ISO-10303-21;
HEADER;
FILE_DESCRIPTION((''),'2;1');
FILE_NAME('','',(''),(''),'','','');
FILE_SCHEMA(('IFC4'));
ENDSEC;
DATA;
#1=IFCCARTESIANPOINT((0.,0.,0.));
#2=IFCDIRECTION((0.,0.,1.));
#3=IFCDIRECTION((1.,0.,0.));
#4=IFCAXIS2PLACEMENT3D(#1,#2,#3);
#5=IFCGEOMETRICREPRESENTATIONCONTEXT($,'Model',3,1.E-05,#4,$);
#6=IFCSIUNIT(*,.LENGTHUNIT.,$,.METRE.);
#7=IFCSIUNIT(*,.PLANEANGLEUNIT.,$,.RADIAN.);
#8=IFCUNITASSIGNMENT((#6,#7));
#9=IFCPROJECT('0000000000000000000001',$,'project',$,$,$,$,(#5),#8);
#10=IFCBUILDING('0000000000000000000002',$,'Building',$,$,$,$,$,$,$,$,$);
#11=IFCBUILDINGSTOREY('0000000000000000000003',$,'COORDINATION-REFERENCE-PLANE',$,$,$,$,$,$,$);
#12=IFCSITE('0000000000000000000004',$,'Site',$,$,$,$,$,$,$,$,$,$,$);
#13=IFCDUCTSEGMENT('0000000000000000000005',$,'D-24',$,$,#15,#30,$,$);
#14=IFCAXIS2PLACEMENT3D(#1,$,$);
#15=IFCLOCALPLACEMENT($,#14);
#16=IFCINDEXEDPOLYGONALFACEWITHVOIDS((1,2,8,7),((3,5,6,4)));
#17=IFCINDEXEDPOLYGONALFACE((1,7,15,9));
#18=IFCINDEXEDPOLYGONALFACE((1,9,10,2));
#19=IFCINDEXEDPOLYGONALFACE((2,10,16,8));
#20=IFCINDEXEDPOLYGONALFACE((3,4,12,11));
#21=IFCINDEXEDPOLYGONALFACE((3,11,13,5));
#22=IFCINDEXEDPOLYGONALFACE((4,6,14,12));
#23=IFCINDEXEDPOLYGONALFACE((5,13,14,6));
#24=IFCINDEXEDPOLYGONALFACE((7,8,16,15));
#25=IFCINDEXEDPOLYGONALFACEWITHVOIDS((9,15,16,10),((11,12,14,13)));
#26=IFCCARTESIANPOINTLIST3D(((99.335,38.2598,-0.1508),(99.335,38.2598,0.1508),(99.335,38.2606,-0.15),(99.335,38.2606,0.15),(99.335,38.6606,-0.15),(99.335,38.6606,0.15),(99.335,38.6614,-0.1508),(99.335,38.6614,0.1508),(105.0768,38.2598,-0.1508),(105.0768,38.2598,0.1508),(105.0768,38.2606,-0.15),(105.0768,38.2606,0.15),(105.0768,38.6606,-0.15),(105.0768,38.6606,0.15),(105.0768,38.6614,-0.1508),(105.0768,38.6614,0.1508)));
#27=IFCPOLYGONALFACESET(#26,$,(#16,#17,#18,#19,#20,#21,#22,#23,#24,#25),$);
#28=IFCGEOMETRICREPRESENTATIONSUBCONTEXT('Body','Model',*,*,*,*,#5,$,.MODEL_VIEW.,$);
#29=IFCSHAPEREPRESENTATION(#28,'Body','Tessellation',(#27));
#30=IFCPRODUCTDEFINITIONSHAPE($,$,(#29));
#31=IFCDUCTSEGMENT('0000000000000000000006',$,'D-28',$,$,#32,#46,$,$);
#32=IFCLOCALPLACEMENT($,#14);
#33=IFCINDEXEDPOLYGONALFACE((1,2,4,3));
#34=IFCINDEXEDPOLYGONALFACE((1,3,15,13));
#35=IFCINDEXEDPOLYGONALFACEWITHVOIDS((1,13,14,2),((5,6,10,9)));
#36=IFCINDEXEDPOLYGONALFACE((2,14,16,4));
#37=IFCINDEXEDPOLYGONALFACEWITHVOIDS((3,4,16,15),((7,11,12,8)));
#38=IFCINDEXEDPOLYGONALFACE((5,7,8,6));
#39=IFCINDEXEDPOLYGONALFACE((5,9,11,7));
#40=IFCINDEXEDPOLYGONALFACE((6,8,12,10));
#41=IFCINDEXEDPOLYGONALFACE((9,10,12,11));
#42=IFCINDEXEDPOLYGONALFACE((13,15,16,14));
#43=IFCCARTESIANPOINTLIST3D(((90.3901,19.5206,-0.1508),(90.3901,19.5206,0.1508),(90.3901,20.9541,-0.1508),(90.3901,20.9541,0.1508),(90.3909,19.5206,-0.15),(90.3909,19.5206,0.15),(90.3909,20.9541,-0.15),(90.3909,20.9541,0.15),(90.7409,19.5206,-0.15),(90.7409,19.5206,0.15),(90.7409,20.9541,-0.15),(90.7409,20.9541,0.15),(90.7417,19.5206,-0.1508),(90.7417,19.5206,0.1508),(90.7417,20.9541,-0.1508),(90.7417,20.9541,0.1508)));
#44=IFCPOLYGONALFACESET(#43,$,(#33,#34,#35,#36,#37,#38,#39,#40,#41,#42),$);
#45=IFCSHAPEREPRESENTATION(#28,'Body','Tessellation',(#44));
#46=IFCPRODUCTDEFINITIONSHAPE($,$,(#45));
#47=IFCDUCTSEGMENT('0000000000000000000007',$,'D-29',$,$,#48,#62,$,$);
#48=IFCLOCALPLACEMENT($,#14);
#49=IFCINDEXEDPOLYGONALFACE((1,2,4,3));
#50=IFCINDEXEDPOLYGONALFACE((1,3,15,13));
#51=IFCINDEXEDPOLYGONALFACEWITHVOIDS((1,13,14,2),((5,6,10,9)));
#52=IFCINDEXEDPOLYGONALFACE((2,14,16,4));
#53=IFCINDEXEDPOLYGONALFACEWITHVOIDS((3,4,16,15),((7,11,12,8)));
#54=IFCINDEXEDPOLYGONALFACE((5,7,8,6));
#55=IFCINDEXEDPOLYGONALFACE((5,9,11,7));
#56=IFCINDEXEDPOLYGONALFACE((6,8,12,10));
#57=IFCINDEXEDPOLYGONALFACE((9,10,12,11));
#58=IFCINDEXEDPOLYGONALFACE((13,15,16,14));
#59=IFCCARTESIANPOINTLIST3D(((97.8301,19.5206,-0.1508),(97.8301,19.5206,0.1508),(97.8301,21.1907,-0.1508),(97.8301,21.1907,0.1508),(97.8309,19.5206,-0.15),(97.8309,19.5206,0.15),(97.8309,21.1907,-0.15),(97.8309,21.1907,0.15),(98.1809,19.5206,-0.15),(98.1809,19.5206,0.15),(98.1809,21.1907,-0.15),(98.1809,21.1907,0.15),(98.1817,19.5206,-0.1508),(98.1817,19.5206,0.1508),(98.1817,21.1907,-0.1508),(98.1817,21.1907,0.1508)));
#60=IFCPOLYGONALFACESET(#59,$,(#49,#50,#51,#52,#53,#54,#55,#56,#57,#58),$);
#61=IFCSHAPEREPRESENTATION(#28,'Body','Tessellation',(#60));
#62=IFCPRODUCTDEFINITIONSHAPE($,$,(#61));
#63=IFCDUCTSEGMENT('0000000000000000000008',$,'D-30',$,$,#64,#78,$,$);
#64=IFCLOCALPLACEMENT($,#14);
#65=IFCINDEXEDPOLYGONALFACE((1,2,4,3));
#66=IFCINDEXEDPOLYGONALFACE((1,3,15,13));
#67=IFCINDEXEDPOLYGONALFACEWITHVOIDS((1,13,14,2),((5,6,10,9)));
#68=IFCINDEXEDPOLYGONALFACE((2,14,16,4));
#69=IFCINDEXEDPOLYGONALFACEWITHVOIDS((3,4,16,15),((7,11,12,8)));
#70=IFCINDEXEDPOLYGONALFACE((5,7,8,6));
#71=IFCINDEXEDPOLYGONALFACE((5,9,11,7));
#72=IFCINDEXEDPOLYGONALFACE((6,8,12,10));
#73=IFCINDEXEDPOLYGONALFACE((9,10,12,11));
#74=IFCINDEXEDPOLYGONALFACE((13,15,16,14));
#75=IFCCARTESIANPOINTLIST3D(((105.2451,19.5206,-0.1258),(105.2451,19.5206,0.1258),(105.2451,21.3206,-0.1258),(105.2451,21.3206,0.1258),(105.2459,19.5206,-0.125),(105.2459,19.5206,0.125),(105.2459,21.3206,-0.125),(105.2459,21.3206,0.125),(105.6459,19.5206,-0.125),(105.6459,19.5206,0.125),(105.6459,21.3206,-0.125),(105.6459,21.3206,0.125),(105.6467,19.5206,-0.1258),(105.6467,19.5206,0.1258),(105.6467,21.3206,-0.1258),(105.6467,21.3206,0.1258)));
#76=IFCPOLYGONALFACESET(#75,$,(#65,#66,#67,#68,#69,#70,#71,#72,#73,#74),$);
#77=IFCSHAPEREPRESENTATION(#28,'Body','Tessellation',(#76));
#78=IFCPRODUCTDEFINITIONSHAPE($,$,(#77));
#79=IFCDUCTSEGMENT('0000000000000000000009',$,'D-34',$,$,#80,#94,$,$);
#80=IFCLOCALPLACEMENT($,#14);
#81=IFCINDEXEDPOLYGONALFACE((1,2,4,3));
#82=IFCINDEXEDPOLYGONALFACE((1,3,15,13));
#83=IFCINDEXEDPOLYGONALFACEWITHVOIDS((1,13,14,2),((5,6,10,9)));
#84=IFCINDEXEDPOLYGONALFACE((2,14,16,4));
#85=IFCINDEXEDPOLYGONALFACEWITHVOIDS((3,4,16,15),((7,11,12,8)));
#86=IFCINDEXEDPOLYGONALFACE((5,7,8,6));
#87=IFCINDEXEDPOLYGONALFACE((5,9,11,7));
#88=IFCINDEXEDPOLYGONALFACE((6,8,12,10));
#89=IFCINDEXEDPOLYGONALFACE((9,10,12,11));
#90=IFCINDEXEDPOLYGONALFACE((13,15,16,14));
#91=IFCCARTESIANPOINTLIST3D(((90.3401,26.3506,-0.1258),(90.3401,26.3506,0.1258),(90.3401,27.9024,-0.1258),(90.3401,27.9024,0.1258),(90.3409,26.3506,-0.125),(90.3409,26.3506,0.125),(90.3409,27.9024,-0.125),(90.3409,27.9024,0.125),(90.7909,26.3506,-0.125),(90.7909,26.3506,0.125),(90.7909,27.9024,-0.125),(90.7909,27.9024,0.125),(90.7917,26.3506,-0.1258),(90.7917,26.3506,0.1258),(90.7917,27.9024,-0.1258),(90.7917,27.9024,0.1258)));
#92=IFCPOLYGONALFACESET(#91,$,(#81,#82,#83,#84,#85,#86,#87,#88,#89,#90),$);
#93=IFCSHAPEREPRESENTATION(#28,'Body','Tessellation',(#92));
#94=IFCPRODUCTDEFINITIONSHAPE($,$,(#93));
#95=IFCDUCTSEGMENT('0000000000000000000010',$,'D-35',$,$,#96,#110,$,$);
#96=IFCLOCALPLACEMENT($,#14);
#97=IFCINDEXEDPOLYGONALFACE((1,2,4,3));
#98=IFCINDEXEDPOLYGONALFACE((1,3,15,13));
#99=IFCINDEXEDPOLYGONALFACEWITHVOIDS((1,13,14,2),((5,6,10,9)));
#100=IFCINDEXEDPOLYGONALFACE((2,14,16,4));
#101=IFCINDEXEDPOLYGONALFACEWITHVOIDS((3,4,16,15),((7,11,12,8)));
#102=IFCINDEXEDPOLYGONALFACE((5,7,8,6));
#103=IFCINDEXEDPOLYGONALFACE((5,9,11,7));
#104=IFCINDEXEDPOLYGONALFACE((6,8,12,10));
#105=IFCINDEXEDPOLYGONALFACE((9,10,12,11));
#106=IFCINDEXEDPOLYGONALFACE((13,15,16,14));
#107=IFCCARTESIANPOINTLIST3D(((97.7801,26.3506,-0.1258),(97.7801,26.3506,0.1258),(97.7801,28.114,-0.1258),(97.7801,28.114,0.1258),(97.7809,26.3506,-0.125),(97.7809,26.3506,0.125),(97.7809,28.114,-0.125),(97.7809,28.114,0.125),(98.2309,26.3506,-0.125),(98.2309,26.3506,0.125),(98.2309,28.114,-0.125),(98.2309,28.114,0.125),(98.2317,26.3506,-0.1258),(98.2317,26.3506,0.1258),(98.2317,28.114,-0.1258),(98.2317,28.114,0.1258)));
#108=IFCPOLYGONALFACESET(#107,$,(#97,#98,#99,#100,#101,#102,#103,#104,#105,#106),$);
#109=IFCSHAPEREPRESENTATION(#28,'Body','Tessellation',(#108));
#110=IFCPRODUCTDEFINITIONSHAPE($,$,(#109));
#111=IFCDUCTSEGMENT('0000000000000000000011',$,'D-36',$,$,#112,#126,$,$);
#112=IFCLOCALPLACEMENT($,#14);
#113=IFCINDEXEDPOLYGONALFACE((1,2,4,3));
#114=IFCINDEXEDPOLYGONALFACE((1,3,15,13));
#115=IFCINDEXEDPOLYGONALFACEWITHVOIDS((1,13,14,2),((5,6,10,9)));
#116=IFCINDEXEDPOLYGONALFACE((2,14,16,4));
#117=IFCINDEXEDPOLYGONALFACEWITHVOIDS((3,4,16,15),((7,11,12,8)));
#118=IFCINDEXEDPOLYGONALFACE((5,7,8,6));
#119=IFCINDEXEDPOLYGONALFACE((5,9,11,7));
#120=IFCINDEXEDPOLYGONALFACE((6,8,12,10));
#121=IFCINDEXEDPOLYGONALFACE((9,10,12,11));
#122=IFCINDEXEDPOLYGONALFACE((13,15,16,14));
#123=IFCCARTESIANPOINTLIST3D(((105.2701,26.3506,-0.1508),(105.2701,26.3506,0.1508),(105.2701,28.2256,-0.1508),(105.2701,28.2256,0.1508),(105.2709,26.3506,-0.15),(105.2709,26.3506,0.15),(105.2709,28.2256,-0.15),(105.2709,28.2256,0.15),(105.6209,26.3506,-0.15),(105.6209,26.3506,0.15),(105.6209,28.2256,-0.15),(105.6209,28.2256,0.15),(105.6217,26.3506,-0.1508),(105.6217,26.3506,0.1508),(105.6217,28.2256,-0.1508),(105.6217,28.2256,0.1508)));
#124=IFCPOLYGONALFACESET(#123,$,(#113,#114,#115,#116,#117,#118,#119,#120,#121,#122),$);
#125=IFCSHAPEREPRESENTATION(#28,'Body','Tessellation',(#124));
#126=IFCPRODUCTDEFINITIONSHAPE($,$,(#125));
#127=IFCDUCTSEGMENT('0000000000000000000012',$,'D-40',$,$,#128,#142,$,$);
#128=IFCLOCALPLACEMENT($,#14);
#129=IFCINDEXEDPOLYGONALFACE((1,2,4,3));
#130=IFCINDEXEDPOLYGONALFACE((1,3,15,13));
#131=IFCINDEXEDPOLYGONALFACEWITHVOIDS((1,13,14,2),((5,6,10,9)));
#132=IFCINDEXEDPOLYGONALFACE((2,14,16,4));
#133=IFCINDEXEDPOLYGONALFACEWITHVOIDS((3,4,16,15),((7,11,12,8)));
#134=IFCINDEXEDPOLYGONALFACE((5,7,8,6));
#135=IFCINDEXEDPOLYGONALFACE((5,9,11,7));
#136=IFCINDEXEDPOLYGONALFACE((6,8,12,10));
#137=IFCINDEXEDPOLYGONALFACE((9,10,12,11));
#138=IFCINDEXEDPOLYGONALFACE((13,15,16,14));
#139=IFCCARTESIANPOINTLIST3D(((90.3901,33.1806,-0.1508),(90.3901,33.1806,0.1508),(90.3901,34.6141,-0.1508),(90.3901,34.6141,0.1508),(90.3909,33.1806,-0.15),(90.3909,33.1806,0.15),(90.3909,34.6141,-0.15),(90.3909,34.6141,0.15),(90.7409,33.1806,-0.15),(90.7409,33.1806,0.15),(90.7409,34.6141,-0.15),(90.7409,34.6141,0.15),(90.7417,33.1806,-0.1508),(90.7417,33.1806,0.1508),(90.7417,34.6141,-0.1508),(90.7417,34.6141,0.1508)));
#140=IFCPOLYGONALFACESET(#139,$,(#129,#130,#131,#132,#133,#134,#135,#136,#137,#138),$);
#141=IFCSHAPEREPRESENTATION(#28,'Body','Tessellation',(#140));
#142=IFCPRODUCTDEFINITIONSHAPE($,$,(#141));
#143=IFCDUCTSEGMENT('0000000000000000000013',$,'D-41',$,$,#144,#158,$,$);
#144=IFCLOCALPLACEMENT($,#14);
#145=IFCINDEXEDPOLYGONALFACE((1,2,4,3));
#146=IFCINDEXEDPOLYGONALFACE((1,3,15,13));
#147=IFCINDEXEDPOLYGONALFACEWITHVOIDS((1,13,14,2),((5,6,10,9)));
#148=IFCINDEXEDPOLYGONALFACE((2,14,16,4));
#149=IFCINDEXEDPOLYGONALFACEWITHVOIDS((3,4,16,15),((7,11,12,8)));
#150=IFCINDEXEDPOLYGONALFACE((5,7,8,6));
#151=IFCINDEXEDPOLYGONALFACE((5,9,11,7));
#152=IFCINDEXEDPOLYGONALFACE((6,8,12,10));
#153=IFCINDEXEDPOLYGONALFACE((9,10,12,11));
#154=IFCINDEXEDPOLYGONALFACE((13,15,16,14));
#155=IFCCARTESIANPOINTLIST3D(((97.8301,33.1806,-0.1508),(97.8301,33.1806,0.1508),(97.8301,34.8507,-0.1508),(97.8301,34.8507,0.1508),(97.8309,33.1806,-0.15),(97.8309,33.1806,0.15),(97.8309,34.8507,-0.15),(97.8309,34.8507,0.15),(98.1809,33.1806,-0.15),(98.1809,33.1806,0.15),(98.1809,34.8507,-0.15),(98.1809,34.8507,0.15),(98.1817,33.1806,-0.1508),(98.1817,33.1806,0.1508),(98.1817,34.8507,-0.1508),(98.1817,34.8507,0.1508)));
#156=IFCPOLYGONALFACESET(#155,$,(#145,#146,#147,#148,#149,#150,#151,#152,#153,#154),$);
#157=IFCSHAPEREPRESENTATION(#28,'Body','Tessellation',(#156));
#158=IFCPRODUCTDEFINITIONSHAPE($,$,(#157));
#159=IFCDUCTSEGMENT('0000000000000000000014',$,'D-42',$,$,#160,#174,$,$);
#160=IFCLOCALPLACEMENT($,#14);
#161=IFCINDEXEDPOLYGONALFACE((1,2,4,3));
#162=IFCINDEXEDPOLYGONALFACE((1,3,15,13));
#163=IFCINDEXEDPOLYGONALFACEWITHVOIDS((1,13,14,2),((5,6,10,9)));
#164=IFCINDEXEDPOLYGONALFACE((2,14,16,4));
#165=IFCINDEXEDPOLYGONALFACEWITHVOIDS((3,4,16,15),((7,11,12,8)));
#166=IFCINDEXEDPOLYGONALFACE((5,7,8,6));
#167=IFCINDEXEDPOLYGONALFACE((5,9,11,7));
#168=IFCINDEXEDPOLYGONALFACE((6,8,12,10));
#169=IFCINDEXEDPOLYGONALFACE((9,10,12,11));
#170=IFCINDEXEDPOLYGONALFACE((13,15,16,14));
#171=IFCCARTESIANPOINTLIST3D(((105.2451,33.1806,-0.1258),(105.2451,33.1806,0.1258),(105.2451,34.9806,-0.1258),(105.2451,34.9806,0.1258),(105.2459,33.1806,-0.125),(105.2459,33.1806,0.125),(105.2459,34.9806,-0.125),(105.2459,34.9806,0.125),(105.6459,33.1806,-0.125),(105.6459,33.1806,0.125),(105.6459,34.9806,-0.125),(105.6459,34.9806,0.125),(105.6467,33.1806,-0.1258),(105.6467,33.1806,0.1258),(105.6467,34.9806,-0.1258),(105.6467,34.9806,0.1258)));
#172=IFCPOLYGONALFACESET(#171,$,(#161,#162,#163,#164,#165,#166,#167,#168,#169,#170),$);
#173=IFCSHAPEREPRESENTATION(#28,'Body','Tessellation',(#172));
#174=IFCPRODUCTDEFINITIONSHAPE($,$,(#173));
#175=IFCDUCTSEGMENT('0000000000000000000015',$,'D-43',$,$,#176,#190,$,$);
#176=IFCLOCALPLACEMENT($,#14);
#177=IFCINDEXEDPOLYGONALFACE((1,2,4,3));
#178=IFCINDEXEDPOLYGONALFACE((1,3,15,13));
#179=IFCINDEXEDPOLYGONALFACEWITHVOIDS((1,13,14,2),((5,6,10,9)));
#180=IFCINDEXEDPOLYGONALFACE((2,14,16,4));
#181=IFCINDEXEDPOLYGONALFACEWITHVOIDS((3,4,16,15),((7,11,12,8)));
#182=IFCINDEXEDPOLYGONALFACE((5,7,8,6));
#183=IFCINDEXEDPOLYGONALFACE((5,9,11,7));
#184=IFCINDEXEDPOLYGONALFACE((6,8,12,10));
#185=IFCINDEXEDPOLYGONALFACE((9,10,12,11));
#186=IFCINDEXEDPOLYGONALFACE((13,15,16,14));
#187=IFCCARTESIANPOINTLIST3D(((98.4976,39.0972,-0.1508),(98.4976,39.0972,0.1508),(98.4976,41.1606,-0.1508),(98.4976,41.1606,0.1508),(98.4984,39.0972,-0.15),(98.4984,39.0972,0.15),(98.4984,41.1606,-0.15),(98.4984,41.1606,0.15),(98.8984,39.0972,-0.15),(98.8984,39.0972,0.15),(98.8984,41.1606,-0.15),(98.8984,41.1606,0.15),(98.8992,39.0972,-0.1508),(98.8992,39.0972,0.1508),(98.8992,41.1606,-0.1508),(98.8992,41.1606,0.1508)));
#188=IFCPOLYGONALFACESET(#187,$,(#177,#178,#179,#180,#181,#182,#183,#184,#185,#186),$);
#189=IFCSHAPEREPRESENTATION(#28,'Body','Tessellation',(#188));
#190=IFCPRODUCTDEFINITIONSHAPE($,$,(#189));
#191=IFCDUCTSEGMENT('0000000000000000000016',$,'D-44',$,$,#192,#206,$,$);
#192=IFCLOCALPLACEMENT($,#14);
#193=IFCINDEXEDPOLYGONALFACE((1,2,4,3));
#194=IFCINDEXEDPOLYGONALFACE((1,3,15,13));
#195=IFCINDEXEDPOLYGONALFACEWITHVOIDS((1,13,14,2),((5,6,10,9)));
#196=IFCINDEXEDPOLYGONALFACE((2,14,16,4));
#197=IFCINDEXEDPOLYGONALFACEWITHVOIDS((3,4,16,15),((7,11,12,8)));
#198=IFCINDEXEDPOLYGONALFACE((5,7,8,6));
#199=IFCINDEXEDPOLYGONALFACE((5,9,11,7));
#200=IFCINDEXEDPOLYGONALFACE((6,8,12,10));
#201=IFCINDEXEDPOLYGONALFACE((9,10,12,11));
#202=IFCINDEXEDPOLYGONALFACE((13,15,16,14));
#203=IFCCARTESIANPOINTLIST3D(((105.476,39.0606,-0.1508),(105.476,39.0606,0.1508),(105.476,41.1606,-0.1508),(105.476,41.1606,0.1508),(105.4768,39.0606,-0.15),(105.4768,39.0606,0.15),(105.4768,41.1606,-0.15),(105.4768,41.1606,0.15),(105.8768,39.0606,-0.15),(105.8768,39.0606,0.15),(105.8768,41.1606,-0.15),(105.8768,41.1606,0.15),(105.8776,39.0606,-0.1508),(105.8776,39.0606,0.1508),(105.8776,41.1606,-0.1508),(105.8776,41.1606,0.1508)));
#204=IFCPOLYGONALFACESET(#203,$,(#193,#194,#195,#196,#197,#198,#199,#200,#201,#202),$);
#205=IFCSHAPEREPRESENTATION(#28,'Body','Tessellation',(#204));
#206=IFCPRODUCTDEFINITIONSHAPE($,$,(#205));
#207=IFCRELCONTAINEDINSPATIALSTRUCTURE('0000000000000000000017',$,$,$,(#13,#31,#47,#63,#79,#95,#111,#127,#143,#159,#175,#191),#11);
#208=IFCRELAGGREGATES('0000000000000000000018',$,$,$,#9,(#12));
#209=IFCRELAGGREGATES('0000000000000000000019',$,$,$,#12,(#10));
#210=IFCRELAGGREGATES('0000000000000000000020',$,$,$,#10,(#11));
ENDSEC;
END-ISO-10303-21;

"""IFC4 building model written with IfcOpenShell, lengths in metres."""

from ifc_helpers import new_model, si_unit, frame, origin, origin_with_axes, place, context, subcontext, project, spatial, hollow_rectangle, extrude, element, save


model = new_model("IFC4")

# Units and contexts
model_context = context("Model", 3, precision=1e-05, world=origin_with_axes())
body_context = subcontext(model_context, "Body", "Model", "MODEL_VIEW")
ifc_project = project(units=[si_unit("LENGTHUNIT", "METRE"), si_unit("PLANEANGLEUNIT", "RADIAN")], contexts=[model_context])

# Site, building, storey
site = spatial("IfcSite", under=ifc_project, Name="Site")
building = spatial("IfcBuilding", under=site, Name="Building")
storey = spatial("IfcBuildingStorey", under=building, Name="COORDINATION-REFERENCE-PLANE")

# Duct segments
duct_segment_1_placement = place(None, frame((99.335, 38.4606, 0.0), z_axis=(1.0, 0.0, 0.0), x_axis=(0.0, 1.0, 0.0)))
element("IfcDuctSegment", 1, at=duct_segment_1_placement, inside=storey, Name="D-24", context=body_context, shape_type="SweptSolid", body=[
    extrude(hollow_rectangle(XDim=0.4016, YDim=0.3016, WallThickness=0.0008), origin(), (0.0, 0.0, 1.0), 5.7417),
])
duct_segment_2_placement = place(None, frame((90.5659, 19.5206, 0.0), z_axis=(0.0, 1.0, 0.0), x_axis=(1.0, 0.0, 0.0)))
element("IfcDuctSegment", 2, at=duct_segment_2_placement, inside=storey, Name="D-28", context=body_context, shape_type="SweptSolid", body=[
    extrude(hollow_rectangle(XDim=0.3516, YDim=0.3016, WallThickness=0.0008), origin(), (0.0, 0.0, 1.0), 1.4335),
])
duct_segment_3_placement = place(None, frame((98.0059, 19.5206, 0.0), z_axis=(0.0, 1.0, 0.0), x_axis=(1.0, 0.0, 0.0)))
element("IfcDuctSegment", 3, at=duct_segment_3_placement, inside=storey, Name="D-29", context=body_context, shape_type="SweptSolid", body=[
    extrude(hollow_rectangle(XDim=0.3516, YDim=0.3016, WallThickness=0.0008), origin(), (0.0, 0.0, 1.0), 1.6701),
])
duct_segment_4_placement = place(None, frame((105.4459, 19.5206, 0.0), z_axis=(0.0, 1.0, 0.0), x_axis=(1.0, 0.0, 0.0)))
element("IfcDuctSegment", 4, at=duct_segment_4_placement, inside=storey, Name="D-30", context=body_context, shape_type="SweptSolid", body=[
    extrude(hollow_rectangle(XDim=0.4016, YDim=0.2516, WallThickness=0.0008), origin(), (0.0, 0.0, 1.0), 1.8),
])
duct_segment_5_placement = place(None, frame((90.5659, 26.3506, 0.0), z_axis=(0.0, 1.0, 0.0), x_axis=(1.0, 0.0, 0.0)))
element("IfcDuctSegment", 5, at=duct_segment_5_placement, inside=storey, Name="D-34", context=body_context, shape_type="SweptSolid", body=[
    extrude(hollow_rectangle(XDim=0.4516, YDim=0.2516, WallThickness=0.0008), origin(), (0.0, 0.0, 1.0), 1.5518),
])
duct_segment_6_placement = place(None, frame((98.0059, 26.3506, 0.0), z_axis=(0.0, 1.0, 0.0), x_axis=(1.0, 0.0, 0.0)))
element("IfcDuctSegment", 6, at=duct_segment_6_placement, inside=storey, Name="D-35", context=body_context, shape_type="SweptSolid", body=[
    extrude(hollow_rectangle(XDim=0.4516, YDim=0.2516, WallThickness=0.0008), origin(), (0.0, 0.0, 1.0), 1.7634),
])
duct_segment_7_placement = place(None, frame((105.4459, 26.3506, 0.0), z_axis=(0.0, 1.0, 0.0), x_axis=(1.0, 0.0, 0.0)))
element("IfcDuctSegment", 7, at=duct_segment_7_placement, inside=storey, Name="D-36", context=body_context, shape_type="SweptSolid", body=[
    extrude(hollow_rectangle(XDim=0.3516, YDim=0.3016, WallThickness=0.0008), origin(), (0.0, 0.0, 1.0), 1.875),
])
duct_segment_8_placement = place(None, frame((90.5659, 33.1806, 0.0), z_axis=(0.0, 1.0, 0.0), x_axis=(1.0, 0.0, 0.0)))
element("IfcDuctSegment", 8, at=duct_segment_8_placement, inside=storey, Name="D-40", context=body_context, shape_type="SweptSolid", body=[
    extrude(hollow_rectangle(XDim=0.3516, YDim=0.3016, WallThickness=0.0008), origin(), (0.0, 0.0, 1.0), 1.4335),
])
duct_segment_9_placement = place(None, frame((98.0059, 33.1806, 0.0), z_axis=(0.0, 1.0, 0.0), x_axis=(1.0, 0.0, 0.0)))
element("IfcDuctSegment", 9, at=duct_segment_9_placement, inside=storey, Name="D-41", context=body_context, shape_type="SweptSolid", body=[
    extrude(hollow_rectangle(XDim=0.3516, YDim=0.3016, WallThickness=0.0008), origin(), (0.0, 0.0, 1.0), 1.6701),
])
duct_segment_10_placement = place(None, frame((105.4459, 33.1806, 0.0), z_axis=(0.0, 1.0, 0.0), x_axis=(1.0, 0.0, 0.0)))
element("IfcDuctSegment", 10, at=duct_segment_10_placement, inside=storey, Name="D-42", context=body_context, shape_type="SweptSolid", body=[
    extrude(hollow_rectangle(XDim=0.4016, YDim=0.2516, WallThickness=0.0008), origin(), (0.0, 0.0, 1.0), 1.8),
])
duct_segment_11_placement = place(None, frame((98.6984, 39.0972, 0.0), z_axis=(0.0, 1.0, 0.0), x_axis=(1.0, 0.0, 0.0)))
element("IfcDuctSegment", 11, at=duct_segment_11_placement, inside=storey, Name="D-43", context=body_context, shape_type="SweptSolid", body=[
    extrude(hollow_rectangle(XDim=0.4016, YDim=0.3016, WallThickness=0.0008), origin(), (0.0, 0.0, 1.0), 2.0634),
])
duct_segment_12_placement = place(None, frame((105.6768, 39.0606, 0.0), z_axis=(0.0, 1.0, 0.0), x_axis=(1.0, 0.0, 0.0)))
element("IfcDuctSegment", 12, at=duct_segment_12_placement, inside=storey, Name="D-44", context=body_context, shape_type="SweptSolid", body=[
    extrude(hollow_rectangle(XDim=0.4016, YDim=0.3016, WallThickness=0.0008), origin(), (0.0, 0.0, 1.0), 2.1),
])

save(model, "model.ifc")
